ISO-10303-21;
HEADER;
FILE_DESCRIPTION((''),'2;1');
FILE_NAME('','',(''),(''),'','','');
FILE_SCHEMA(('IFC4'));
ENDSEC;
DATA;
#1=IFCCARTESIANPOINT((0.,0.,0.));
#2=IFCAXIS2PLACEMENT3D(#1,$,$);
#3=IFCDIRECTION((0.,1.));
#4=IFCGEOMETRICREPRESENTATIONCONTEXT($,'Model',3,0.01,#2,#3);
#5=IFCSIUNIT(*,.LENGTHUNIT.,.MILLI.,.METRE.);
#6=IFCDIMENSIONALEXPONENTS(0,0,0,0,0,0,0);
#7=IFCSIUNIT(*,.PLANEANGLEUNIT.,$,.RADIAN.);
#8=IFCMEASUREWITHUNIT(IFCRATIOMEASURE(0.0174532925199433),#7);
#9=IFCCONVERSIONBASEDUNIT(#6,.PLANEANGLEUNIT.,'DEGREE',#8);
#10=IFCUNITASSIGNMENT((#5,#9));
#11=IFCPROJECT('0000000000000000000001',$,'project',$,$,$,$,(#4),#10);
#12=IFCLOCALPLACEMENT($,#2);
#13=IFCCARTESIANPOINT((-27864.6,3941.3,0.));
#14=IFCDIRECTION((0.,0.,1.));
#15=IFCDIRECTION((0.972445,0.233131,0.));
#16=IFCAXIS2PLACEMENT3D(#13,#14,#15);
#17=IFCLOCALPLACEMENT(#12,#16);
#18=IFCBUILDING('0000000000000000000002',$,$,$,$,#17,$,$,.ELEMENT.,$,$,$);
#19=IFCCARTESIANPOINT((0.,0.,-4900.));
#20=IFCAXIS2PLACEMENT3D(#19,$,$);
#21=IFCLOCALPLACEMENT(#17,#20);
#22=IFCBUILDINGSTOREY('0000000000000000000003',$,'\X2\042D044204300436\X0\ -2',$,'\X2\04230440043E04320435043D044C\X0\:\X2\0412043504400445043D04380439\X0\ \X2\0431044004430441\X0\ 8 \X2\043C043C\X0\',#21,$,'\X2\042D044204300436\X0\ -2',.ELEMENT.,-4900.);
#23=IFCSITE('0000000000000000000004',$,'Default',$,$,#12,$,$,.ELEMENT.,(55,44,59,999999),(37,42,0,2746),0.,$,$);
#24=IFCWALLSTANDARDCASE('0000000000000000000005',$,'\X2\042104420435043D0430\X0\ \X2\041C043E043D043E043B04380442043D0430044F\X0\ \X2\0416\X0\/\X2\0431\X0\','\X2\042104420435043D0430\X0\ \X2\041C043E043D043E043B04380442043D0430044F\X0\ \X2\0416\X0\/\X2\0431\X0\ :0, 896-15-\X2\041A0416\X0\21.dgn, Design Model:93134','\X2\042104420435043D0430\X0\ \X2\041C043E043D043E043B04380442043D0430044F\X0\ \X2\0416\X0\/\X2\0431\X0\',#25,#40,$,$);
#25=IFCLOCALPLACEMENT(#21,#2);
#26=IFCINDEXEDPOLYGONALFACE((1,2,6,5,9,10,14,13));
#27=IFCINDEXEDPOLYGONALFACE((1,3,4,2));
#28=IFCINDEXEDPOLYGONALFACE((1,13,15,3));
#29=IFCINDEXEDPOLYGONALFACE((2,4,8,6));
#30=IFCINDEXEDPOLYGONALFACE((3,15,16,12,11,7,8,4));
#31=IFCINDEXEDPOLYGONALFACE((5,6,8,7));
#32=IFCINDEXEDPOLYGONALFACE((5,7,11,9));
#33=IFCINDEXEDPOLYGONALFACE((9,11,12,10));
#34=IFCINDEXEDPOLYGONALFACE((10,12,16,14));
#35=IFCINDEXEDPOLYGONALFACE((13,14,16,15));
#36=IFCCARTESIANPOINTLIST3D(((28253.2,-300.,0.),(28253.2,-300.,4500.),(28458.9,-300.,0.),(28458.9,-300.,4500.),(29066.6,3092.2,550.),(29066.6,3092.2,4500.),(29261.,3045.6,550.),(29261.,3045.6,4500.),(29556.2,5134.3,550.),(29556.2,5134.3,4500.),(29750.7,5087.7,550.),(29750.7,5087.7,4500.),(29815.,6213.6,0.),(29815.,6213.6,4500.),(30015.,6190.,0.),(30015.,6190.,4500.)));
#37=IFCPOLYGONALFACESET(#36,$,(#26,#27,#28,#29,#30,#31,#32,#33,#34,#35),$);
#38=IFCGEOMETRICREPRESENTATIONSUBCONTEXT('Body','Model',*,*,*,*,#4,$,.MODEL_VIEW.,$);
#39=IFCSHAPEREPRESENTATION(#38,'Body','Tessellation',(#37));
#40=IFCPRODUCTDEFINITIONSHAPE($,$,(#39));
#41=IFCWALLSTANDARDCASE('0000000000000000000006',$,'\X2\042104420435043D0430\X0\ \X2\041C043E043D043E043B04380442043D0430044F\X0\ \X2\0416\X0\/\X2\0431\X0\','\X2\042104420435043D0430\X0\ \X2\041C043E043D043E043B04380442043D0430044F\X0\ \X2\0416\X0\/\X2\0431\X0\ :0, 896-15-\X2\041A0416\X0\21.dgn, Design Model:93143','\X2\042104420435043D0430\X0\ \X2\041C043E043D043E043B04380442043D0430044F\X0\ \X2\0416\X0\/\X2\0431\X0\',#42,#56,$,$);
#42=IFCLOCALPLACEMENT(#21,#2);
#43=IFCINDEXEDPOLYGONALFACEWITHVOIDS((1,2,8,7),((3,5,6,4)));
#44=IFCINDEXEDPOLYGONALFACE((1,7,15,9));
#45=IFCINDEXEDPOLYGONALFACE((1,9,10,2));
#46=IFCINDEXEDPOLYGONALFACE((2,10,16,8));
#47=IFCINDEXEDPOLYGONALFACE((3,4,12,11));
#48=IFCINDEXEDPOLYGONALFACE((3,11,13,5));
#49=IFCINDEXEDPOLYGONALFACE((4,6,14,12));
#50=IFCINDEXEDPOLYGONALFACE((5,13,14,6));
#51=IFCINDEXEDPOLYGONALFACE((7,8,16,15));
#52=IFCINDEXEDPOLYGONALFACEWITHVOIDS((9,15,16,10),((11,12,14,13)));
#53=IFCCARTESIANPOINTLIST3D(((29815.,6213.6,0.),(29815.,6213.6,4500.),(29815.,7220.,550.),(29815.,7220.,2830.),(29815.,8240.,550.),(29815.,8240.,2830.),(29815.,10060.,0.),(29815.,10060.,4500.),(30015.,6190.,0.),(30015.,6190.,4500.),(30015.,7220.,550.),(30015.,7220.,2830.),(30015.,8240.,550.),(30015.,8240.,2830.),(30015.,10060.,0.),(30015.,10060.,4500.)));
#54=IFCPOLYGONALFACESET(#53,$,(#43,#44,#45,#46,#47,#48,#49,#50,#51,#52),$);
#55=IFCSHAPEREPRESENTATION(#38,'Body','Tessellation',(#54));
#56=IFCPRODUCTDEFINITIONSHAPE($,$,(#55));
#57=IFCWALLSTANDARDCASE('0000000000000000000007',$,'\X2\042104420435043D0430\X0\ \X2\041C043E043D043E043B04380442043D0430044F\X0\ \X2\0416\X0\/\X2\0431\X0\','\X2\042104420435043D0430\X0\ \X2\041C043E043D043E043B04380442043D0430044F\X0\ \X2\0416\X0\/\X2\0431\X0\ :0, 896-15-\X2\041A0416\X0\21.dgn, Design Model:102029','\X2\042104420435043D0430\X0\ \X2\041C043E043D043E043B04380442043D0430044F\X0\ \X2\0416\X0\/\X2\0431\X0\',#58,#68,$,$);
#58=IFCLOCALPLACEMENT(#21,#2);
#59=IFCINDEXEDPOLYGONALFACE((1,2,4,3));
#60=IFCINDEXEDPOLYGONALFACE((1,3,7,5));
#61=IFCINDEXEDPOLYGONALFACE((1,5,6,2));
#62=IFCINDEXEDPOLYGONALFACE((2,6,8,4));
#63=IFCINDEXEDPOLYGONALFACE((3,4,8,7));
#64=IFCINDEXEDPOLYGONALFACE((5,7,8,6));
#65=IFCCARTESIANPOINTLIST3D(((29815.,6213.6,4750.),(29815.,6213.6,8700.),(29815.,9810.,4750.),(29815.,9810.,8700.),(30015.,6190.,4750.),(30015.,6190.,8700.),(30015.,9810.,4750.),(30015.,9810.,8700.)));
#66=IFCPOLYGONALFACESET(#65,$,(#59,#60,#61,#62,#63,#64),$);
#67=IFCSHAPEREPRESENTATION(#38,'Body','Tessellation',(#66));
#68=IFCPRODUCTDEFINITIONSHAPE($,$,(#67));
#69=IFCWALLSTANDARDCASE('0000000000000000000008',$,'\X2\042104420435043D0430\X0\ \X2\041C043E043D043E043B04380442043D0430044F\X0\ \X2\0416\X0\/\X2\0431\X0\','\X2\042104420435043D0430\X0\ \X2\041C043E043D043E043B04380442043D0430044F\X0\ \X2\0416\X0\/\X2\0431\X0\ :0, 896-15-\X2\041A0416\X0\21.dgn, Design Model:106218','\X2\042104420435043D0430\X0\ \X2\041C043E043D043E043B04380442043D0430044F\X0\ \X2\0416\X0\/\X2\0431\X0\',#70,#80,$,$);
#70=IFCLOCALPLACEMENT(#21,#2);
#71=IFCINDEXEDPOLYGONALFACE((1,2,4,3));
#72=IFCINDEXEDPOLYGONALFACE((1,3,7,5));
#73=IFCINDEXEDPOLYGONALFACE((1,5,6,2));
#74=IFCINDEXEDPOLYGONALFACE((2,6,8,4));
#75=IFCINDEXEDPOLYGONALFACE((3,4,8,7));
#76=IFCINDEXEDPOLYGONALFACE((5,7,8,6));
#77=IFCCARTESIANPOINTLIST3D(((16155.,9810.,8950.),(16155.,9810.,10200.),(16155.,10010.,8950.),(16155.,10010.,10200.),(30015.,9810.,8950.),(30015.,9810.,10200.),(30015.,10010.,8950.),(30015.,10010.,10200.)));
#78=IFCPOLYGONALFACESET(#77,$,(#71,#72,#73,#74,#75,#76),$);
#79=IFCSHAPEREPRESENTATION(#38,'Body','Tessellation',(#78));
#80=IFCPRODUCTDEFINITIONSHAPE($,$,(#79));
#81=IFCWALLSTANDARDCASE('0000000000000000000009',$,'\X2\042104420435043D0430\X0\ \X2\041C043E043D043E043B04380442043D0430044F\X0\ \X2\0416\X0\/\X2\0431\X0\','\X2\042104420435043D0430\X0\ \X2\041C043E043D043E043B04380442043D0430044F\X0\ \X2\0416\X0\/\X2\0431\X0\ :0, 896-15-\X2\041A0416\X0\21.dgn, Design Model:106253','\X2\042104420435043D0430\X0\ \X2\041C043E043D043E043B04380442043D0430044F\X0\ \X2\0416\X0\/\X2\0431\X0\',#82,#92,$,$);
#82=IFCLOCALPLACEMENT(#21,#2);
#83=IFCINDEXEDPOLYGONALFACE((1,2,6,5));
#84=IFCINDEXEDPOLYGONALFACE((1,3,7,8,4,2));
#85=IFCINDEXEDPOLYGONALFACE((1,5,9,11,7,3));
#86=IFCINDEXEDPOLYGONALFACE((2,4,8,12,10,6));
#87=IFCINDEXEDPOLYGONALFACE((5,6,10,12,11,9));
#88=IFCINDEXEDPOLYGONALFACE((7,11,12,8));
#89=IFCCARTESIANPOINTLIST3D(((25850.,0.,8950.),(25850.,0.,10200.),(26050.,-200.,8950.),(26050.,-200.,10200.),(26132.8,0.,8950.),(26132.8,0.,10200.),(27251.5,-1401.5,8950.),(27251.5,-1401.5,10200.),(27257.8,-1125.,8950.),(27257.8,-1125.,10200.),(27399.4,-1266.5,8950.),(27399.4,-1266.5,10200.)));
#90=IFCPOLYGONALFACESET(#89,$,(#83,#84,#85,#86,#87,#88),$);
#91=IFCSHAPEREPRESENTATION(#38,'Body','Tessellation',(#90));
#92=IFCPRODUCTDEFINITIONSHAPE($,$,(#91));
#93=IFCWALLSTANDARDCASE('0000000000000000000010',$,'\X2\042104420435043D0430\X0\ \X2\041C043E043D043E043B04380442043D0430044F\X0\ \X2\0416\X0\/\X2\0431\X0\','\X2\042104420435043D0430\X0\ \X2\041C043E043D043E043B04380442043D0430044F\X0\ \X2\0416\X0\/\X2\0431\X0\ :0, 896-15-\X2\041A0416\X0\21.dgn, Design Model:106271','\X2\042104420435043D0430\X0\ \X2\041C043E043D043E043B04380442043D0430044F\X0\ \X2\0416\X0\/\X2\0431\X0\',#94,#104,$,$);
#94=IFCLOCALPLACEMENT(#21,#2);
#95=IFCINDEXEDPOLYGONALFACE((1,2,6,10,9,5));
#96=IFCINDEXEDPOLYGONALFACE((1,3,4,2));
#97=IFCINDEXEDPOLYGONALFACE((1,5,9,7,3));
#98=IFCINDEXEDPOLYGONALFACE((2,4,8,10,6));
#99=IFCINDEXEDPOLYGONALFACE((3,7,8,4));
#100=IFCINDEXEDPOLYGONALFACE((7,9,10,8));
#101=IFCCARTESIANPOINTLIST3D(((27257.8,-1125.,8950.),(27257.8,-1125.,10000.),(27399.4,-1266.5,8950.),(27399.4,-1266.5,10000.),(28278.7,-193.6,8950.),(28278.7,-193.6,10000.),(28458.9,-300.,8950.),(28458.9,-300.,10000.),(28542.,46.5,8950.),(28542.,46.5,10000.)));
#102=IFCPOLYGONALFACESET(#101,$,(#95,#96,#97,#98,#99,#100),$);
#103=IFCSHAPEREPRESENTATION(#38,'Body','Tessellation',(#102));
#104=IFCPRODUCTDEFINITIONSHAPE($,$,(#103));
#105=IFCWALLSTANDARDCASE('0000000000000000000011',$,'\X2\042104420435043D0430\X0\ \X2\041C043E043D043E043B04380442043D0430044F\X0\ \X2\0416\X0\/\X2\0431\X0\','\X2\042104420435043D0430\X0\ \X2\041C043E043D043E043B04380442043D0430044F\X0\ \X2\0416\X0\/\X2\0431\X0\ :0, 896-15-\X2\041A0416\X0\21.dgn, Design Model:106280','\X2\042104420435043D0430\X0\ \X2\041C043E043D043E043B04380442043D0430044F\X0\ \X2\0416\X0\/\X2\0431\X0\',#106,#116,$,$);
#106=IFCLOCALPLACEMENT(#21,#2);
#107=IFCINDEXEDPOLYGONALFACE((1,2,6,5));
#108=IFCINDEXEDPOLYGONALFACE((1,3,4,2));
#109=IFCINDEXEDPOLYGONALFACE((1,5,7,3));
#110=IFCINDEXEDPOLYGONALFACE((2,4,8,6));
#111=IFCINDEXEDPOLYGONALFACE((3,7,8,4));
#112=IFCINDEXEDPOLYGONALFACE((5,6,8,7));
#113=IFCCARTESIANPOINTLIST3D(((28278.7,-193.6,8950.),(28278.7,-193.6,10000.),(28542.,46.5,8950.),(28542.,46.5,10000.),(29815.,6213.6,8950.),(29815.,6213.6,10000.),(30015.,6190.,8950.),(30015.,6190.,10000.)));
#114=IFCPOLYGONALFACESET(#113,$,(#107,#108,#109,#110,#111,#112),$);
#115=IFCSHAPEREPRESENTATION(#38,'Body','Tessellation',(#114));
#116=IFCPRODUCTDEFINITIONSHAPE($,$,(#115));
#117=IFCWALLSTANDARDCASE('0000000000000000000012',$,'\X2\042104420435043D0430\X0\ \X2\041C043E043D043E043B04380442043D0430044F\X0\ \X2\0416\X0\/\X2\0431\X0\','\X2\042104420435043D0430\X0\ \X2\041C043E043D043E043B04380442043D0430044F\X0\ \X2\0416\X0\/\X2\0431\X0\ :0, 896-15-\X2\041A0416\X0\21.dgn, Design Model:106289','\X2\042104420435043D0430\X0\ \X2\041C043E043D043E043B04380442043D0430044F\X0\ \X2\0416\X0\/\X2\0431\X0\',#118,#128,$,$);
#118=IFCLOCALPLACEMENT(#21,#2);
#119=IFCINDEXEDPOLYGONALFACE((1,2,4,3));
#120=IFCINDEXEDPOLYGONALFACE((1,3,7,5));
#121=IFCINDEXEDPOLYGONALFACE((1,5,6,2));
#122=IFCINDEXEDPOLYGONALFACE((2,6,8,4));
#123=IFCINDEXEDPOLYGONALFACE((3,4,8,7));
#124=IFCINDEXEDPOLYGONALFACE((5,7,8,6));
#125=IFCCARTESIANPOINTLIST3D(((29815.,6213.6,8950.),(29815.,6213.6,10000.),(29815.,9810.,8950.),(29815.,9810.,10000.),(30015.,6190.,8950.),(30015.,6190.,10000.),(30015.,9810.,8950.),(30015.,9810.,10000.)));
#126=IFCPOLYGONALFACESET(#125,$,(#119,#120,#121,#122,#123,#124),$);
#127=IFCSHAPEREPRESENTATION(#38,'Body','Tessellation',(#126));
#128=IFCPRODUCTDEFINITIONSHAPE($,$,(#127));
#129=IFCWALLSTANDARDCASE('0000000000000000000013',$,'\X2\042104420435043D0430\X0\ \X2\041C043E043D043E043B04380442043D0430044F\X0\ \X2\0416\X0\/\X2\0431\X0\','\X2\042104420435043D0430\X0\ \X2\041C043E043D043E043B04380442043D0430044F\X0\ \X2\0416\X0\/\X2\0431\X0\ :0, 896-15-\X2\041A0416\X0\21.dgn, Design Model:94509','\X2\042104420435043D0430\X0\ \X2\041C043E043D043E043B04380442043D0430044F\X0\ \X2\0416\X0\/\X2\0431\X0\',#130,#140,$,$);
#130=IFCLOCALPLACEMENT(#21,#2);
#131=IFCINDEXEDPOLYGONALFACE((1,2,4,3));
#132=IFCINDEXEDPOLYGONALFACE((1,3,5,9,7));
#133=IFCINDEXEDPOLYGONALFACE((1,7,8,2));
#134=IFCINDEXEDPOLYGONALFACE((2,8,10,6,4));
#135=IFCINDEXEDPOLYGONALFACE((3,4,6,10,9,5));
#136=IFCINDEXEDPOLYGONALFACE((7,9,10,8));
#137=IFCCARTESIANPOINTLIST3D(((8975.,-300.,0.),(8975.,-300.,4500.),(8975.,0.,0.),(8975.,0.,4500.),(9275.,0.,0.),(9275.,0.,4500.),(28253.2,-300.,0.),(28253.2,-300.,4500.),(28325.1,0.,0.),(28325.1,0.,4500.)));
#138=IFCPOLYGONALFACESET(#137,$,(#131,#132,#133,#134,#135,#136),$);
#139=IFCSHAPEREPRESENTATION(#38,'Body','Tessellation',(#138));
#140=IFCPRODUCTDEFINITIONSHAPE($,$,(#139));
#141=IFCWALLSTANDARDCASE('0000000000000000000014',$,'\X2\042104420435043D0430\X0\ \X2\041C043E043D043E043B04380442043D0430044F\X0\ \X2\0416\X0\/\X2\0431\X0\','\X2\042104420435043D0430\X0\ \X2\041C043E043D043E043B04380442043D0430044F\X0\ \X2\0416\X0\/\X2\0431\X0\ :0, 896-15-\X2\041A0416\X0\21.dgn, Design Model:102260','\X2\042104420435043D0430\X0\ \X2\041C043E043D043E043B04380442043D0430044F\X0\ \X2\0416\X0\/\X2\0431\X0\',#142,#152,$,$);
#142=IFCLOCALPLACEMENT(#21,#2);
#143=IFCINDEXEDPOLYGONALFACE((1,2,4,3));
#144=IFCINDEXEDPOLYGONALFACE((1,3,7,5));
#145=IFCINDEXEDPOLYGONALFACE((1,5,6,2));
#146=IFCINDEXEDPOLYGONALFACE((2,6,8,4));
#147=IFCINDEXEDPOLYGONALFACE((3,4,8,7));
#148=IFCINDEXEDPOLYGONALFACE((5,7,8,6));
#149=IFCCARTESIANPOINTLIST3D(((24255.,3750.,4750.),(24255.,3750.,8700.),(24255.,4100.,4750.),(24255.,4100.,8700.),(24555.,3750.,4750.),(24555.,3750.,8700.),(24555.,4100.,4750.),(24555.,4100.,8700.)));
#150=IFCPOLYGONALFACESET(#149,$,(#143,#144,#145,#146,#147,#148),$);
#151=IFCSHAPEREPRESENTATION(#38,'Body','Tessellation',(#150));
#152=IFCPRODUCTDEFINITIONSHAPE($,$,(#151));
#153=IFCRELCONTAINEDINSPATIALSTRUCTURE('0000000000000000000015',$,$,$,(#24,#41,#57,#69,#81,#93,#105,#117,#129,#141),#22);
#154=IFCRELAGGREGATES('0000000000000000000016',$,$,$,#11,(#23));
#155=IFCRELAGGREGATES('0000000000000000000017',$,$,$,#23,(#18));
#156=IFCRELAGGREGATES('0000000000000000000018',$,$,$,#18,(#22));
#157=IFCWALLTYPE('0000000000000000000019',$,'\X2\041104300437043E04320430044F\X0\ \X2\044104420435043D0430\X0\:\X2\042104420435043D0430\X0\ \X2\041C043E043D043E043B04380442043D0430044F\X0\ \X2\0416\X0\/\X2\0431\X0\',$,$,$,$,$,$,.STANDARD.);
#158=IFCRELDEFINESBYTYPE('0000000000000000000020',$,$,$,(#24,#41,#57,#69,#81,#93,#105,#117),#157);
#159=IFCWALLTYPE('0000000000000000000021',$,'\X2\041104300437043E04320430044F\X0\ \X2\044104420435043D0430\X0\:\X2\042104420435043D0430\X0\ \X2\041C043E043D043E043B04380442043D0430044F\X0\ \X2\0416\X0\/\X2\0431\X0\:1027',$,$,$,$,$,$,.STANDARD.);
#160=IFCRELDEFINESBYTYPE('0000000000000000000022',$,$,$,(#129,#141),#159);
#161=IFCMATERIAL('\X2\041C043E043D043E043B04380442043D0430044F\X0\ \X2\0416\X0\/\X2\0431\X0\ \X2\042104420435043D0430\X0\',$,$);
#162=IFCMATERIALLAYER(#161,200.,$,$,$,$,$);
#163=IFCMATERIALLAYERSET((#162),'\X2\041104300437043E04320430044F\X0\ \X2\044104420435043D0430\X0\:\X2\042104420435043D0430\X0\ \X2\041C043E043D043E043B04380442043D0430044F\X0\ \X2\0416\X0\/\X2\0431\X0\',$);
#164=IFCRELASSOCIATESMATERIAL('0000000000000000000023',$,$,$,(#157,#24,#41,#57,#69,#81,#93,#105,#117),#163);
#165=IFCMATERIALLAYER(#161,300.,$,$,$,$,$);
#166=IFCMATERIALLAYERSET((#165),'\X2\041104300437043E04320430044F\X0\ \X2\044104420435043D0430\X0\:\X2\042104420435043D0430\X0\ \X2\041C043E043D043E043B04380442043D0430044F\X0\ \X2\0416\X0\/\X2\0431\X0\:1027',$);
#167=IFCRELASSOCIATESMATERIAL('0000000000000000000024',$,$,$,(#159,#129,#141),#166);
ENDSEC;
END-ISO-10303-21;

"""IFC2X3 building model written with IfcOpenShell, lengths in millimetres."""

from ifc_helpers import new_model, entity, si_unit, converted_unit, direction, frame, frame_2d, origin, origin_2d_with_axis, place, context, subcontext, project, spatial, polyline, rectangle, outline, extrude, material, layer, layer_set, layer_usage, type_object, element, save


model = new_model("IFC2X3")

# Units and contexts
model_context = context("Model", 3, precision=0.01, world=origin(), true_north=direction((0.0, 1.0)))
body_context = subcontext(model_context, "Body", "Model", "MODEL_VIEW")
ifc_project = project(units=[si_unit("LENGTHUNIT", "METRE", prefix="MILLI"), converted_unit("PLANEANGLEUNIT", "DEGREE", entity("IfcRatioMeasure", 0.0174532925199433), si_unit("PLANEANGLEUNIT", "RADIAN"), dimensions=[0, 0, 0, 0, 0, 0, 0])], contexts=[model_context])

# Site, building, storey
site_placement = place(None, origin())
site = spatial("IfcSite", under=ifc_project, at=site_placement, Name="Default", CompositionType="ELEMENT", RefLatitude=(55, 44, 59, 999999), RefLongitude=(37, 42, 0, 2746), RefElevation=0.0)
building_placement = place(site_placement, frame((-27864.6, 3941.3, 0.0), z_axis=(0.0, 0.0, 1.0), x_axis=(0.972445, 0.233131, 0.0)))
building = spatial("IfcBuilding", under=site, at=building_placement, CompositionType="ELEMENT")
storey_placement = place(building_placement, frame((0.0, 0.0, -4900.0)))
storey = spatial("IfcBuildingStorey", under=building, at=storey_placement, Name="Этаж -2", ObjectType="Уровень:Верхний брус 8 мм", LongName="Этаж -2", CompositionType="ELEMENT", Elevation=-4900.0)

# Walls, openings
ifc_material = material(Name="Монолитная Ж/б Стена")
ifc_layer_1 = layer(ifc_material, 200.0)
ifc_layer_set_1 = layer_set([ifc_layer_1], Name="Базовая стена:Стена Монолитная Ж/б")
ifc_layer_usage_1 = layer_usage(ifc_layer_set_1, "AXIS2", "NEGATIVE", 100.0)
wall_type_1 = type_object("IfcWallType", Name="Базовая стена:Стена Монолитная Ж/б", PredefinedType="STANDARD", material=ifc_layer_set_1)
wall_1_placement = place(storey_placement, frame((29917.8, 6213.3, 0.0), z_axis=(0.0, 0.0, 1.0), x_axis=(-0.233165, -0.972437, 0.0)))
wall_1 = element("IfcWallStandardCase", 1, at=wall_1_placement, inside=storey, type_object=wall_type_1, material=ifc_layer_usage_1, Name="Стена Монолитная Ж/б", Description="Стена Монолитная Ж/б :0, 896-15-КЖ21.dgn, Design Model:93134", ObjectType="Стена Монолитная Ж/б", context=body_context, shape_type="SweptSolid", body=[
    extrude(outline(polyline([(6721.9, -100.0), (6674.0, 100.0), (0.0, 100.0), (23.6, -100.0), (3343.4, -100.0), (3593.4, -100.0), (6413.4, -100.0), (6721.9, -100.0)])), origin(), (0.0, 0.0, 1.0), 4500.0),
])
opening_1_placement = place(wall_1_placement, origin())
element("IfcOpeningElement", 2, at=opening_1_placement, cuts=wall_1, ObjectType="Opening", context=body_context, shape_type="SweptSolid", body=[
    extrude(rectangle(XDim=3950.0, YDim=2100.0, at=frame_2d((0.0, 0.0), x_axis=(1.0, 0.0))), frame((2183.6, -100.0, 2525.0), z_axis=(0.0, 1.0, 0.0), x_axis=(0.0, 0.0, -1.0)), (0.0, 0.0, 1.0), 200.0),
])
ifc_layer_usage_2 = layer_usage(ifc_layer_set_1, "AXIS2", "NEGATIVE", 100.0)
wall_2_placement = place(storey_placement, frame((29915.0, 10060.0, 0.0), z_axis=(0.0, 0.0, 1.0), x_axis=(0.0, -1.0, 0.0)))
wall_2 = element("IfcWallStandardCase", 3, at=wall_2_placement, inside=storey, type_object=wall_type_1, material=ifc_layer_usage_2, Name="Стена Монолитная Ж/б", Description="Стена Монолитная Ж/б :0, 896-15-КЖ21.dgn, Design Model:93143", ObjectType="Стена Монолитная Ж/б", context=body_context, shape_type="SweptSolid", body=[
    extrude(outline(polyline([(3846.4, -100.0), (3870.0, 100.0), (0.0, 100.0), (0.0, -100.0), (300.0, -100.0), (3846.4, -100.0)])), origin(), (0.0, 0.0, 1.0), 4500.0),
])
opening_2_placement = place(wall_2_placement, origin())
element("IfcOpeningElement", 4, at=opening_2_placement, cuts=wall_2, ObjectType="Opening", context=body_context, shape_type="SweptSolid", body=[
    extrude(rectangle(XDim=2280.0, YDim=1020.0, at=origin_2d_with_axis()), frame((2330.0, -100.0, 1690.0), z_axis=(0.0, 1.0, 0.0), x_axis=(0.0, 0.0, -1.0)), (0.0, 0.0, 1.0), 200.0),
])

# Walls
ifc_layer_usage_3 = layer_usage(ifc_layer_set_1, "AXIS2", "NEGATIVE", 100.0)
wall_3_placement = place(storey_placement, frame((29915.0, 6190.0, 4750.0), z_axis=(0.0, 0.0, 1.0), x_axis=(0.0, 1.0, 0.0)))
element("IfcWallStandardCase", 5, at=wall_3_placement, inside=storey, type_object=wall_type_1, material=ifc_layer_usage_3, Name="Стена Монолитная Ж/б", Description="Стена Монолитная Ж/б :0, 896-15-КЖ21.dgn, Design Model:102029", ObjectType="Стена Монолитная Ж/б", context=body_context, shape_type="SweptSolid", body=[
    extrude(outline(polyline([(3620.0, -100.0), (3620.0, 100.0), (23.6, 100.0), (0.0, -100.0), (3620.0, -100.0)])), origin(), (0.0, 0.0, 1.0), 3950.0),
])
ifc_layer_usage_4 = layer_usage(ifc_layer_set_1, "AXIS2", "NEGATIVE", 100.0)
wall_4_placement = place(storey_placement, frame((30015.0, 9910.0, 8950.0), z_axis=(0.0, 0.0, 1.0), x_axis=(-1.0, 0.0, 0.0)))
element("IfcWallStandardCase", 6, at=wall_4_placement, inside=storey, type_object=wall_type_1, material=ifc_layer_usage_4, Name="Стена Монолитная Ж/б", Description="Стена Монолитная Ж/б :0, 896-15-КЖ21.dgn, Design Model:106218", ObjectType="Стена Монолитная Ж/б", context=body_context, shape_type="SweptSolid", body=[
    extrude(rectangle(XDim=13860.0, YDim=200.0, at=frame_2d((6930.0, 0.0), x_axis=(-1.0, 0.0))), origin(), (0.0, 0.0, 1.0), 1250.0),
])
ifc_layer_usage_5 = layer_usage(ifc_layer_set_1, "AXIS2", "NEGATIVE", 100.0)
wall_5_placement = place(storey_placement, frame((25920.7, 70.7, 8950.0), z_axis=(0.0, 0.0, 1.0), x_axis=(0.707107, -0.707107, 0.0)))
element("IfcWallStandardCase", 7, at=wall_5_placement, inside=storey, type_object=wall_type_1, material=ifc_layer_usage_5, Name="Стена Монолитная Ж/б", Description="Стена Монолитная Ж/б :0, 896-15-КЖ21.dgn, Design Model:106253", ObjectType="Стена Монолитная Ж/б", context=body_context, shape_type="SweptSolid", body=[
    extrude(outline(polyline([(1982.0, -100.0), (1991.2, 100.0), (1791.0, 100.0), (200.0, 100.0), (0.0, -100.0), (282.8, -100.0), (1982.0, -100.0)])), origin(), (0.0, 0.0, 1.0), 1250.0),
])
ifc_layer_usage_6 = layer_usage(ifc_layer_set_1, "AXIS2", "NEGATIVE", 100.0)
wall_6_placement = place(storey_placement, frame((28609.3, -27.4, 8950.0), z_axis=(0.0, 0.0, 1.0), x_axis=(-0.738765, -0.673963, 0.0)))
element("IfcWallStandardCase", 8, at=wall_6_placement, inside=storey, type_object=wall_type_1, material=ifc_layer_usage_6, Name="Стена Монолитная Ж/б", Description="Стена Монолитная Ж/б :0, 896-15-КЖ21.dgn, Design Model:106271", ObjectType="Стена Монолитная Ж/б", context=body_context, shape_type="SweptSolid", body=[
    extrude(outline(polyline([(1738.2, -100.0), (1729.0, 100.0), (294.9, 100.0), (0.0, -100.0), (356.3, -100.0), (1738.2, -100.0)])), origin(), (0.0, 0.0, 1.0), 1050.0),
])
ifc_layer_usage_7 = layer_usage(ifc_layer_set_1, "AXIS2", "NEGATIVE", 100.0)
wall_7_placement = place(storey_placement, frame((29917.8, 6213.3, 8950.0), z_axis=(0.0, 0.0, 1.0), x_axis=(-0.233165, -0.972437, 0.0)))
element("IfcWallStandardCase", 9, at=wall_7_placement, inside=storey, type_object=wall_type_1, material=ifc_layer_usage_7, Name="Стена Монолитная Ж/б", Description="Стена Монолитная Ж/б :0, 896-15-КЖ21.dgn, Design Model:106280", ObjectType="Стена Монолитная Ж/б", context=body_context, shape_type="SweptSolid", body=[
    extrude(outline(polyline([(6612.5, -100.0), (6317.6, 100.0), (0.0, 100.0), (23.6, -100.0), (6612.5, -100.0)])), origin(), (0.0, 0.0, 1.0), 1050.0),
])
ifc_layer_usage_8 = layer_usage(ifc_layer_set_1, "AXIS2", "NEGATIVE", 100.0)
wall_8_placement = place(storey_placement, frame((29915.0, 9810.0, 8950.0), z_axis=(0.0, 0.0, 1.0), x_axis=(0.0, -1.0, 0.0)))
element("IfcWallStandardCase", 10, at=wall_8_placement, inside=storey, type_object=wall_type_1, material=ifc_layer_usage_8, Name="Стена Монолитная Ж/б", Description="Стена Монолитная Ж/б :0, 896-15-КЖ21.dgn, Design Model:106289", ObjectType="Стена Монолитная Ж/б", context=body_context, shape_type="SweptSolid", body=[
    extrude(outline(polyline([(3596.4, -100.0), (3620.0, 100.0), (0.0, 100.0), (0.0, -100.0), (3596.4, -100.0)])), origin(), (0.0, 0.0, 1.0), 1050.0),
])
ifc_layer_2 = layer(ifc_material, 300.0)
ifc_layer_set_2 = layer_set([ifc_layer_2], Name="Базовая стена:Стена Монолитная Ж/б:1027")
ifc_layer_usage_9 = layer_usage(ifc_layer_set_2, "AXIS2", "NEGATIVE", 150.0)
wall_type_2 = type_object("IfcWallType", Name="Базовая стена:Стена Монолитная Ж/б:1027", PredefinedType="STANDARD", material=ifc_layer_set_2)
wall_9_placement = place(storey_placement, frame((28325.1, -150.0, 0.0), z_axis=(0.0, 0.0, 1.0), x_axis=(-1.0, 0.0, 0.0)))
element("IfcWallStandardCase", 11, at=wall_9_placement, inside=storey, type_object=wall_type_2, material=ifc_layer_usage_9, Name="Стена Монолитная Ж/б", Description="Стена Монолитная Ж/б :0, 896-15-КЖ21.dgn, Design Model:94509", ObjectType="Стена Монолитная Ж/б", context=body_context, shape_type="SweptSolid", body=[
    extrude(outline(polyline([(19350.1, -150.0), (19350.1, 150.0), (71.9, 150.0), (0.0, -150.0), (19050.1, -150.0), (19350.1, -150.0)])), origin(), (0.0, 0.0, 1.0), 4500.0),
])
ifc_layer_usage_10 = layer_usage(ifc_layer_set_2, "AXIS2", "NEGATIVE", 150.0)
wall_10_placement = place(storey_placement, frame((24405.0, 4100.0, 4750.0), z_axis=(0.0, 0.0, 1.0), x_axis=(0.0, -1.0, 0.0)))
element("IfcWallStandardCase", 12, at=wall_10_placement, inside=storey, type_object=wall_type_2, material=ifc_layer_usage_10, Name="Стена Монолитная Ж/б", Description="Стена Монолитная Ж/б :0, 896-15-КЖ21.dgn, Design Model:102260", ObjectType="Стена Монолитная Ж/б", context=body_context, shape_type="SweptSolid", body=[
    extrude(rectangle(XDim=350.0, YDim=300.0, at=frame_2d((175.0, 0.0), x_axis=(-1.0, 0.0))), origin(), (0.0, 0.0, 1.0), 3950.0),
])

save(model, "model.ifc")
